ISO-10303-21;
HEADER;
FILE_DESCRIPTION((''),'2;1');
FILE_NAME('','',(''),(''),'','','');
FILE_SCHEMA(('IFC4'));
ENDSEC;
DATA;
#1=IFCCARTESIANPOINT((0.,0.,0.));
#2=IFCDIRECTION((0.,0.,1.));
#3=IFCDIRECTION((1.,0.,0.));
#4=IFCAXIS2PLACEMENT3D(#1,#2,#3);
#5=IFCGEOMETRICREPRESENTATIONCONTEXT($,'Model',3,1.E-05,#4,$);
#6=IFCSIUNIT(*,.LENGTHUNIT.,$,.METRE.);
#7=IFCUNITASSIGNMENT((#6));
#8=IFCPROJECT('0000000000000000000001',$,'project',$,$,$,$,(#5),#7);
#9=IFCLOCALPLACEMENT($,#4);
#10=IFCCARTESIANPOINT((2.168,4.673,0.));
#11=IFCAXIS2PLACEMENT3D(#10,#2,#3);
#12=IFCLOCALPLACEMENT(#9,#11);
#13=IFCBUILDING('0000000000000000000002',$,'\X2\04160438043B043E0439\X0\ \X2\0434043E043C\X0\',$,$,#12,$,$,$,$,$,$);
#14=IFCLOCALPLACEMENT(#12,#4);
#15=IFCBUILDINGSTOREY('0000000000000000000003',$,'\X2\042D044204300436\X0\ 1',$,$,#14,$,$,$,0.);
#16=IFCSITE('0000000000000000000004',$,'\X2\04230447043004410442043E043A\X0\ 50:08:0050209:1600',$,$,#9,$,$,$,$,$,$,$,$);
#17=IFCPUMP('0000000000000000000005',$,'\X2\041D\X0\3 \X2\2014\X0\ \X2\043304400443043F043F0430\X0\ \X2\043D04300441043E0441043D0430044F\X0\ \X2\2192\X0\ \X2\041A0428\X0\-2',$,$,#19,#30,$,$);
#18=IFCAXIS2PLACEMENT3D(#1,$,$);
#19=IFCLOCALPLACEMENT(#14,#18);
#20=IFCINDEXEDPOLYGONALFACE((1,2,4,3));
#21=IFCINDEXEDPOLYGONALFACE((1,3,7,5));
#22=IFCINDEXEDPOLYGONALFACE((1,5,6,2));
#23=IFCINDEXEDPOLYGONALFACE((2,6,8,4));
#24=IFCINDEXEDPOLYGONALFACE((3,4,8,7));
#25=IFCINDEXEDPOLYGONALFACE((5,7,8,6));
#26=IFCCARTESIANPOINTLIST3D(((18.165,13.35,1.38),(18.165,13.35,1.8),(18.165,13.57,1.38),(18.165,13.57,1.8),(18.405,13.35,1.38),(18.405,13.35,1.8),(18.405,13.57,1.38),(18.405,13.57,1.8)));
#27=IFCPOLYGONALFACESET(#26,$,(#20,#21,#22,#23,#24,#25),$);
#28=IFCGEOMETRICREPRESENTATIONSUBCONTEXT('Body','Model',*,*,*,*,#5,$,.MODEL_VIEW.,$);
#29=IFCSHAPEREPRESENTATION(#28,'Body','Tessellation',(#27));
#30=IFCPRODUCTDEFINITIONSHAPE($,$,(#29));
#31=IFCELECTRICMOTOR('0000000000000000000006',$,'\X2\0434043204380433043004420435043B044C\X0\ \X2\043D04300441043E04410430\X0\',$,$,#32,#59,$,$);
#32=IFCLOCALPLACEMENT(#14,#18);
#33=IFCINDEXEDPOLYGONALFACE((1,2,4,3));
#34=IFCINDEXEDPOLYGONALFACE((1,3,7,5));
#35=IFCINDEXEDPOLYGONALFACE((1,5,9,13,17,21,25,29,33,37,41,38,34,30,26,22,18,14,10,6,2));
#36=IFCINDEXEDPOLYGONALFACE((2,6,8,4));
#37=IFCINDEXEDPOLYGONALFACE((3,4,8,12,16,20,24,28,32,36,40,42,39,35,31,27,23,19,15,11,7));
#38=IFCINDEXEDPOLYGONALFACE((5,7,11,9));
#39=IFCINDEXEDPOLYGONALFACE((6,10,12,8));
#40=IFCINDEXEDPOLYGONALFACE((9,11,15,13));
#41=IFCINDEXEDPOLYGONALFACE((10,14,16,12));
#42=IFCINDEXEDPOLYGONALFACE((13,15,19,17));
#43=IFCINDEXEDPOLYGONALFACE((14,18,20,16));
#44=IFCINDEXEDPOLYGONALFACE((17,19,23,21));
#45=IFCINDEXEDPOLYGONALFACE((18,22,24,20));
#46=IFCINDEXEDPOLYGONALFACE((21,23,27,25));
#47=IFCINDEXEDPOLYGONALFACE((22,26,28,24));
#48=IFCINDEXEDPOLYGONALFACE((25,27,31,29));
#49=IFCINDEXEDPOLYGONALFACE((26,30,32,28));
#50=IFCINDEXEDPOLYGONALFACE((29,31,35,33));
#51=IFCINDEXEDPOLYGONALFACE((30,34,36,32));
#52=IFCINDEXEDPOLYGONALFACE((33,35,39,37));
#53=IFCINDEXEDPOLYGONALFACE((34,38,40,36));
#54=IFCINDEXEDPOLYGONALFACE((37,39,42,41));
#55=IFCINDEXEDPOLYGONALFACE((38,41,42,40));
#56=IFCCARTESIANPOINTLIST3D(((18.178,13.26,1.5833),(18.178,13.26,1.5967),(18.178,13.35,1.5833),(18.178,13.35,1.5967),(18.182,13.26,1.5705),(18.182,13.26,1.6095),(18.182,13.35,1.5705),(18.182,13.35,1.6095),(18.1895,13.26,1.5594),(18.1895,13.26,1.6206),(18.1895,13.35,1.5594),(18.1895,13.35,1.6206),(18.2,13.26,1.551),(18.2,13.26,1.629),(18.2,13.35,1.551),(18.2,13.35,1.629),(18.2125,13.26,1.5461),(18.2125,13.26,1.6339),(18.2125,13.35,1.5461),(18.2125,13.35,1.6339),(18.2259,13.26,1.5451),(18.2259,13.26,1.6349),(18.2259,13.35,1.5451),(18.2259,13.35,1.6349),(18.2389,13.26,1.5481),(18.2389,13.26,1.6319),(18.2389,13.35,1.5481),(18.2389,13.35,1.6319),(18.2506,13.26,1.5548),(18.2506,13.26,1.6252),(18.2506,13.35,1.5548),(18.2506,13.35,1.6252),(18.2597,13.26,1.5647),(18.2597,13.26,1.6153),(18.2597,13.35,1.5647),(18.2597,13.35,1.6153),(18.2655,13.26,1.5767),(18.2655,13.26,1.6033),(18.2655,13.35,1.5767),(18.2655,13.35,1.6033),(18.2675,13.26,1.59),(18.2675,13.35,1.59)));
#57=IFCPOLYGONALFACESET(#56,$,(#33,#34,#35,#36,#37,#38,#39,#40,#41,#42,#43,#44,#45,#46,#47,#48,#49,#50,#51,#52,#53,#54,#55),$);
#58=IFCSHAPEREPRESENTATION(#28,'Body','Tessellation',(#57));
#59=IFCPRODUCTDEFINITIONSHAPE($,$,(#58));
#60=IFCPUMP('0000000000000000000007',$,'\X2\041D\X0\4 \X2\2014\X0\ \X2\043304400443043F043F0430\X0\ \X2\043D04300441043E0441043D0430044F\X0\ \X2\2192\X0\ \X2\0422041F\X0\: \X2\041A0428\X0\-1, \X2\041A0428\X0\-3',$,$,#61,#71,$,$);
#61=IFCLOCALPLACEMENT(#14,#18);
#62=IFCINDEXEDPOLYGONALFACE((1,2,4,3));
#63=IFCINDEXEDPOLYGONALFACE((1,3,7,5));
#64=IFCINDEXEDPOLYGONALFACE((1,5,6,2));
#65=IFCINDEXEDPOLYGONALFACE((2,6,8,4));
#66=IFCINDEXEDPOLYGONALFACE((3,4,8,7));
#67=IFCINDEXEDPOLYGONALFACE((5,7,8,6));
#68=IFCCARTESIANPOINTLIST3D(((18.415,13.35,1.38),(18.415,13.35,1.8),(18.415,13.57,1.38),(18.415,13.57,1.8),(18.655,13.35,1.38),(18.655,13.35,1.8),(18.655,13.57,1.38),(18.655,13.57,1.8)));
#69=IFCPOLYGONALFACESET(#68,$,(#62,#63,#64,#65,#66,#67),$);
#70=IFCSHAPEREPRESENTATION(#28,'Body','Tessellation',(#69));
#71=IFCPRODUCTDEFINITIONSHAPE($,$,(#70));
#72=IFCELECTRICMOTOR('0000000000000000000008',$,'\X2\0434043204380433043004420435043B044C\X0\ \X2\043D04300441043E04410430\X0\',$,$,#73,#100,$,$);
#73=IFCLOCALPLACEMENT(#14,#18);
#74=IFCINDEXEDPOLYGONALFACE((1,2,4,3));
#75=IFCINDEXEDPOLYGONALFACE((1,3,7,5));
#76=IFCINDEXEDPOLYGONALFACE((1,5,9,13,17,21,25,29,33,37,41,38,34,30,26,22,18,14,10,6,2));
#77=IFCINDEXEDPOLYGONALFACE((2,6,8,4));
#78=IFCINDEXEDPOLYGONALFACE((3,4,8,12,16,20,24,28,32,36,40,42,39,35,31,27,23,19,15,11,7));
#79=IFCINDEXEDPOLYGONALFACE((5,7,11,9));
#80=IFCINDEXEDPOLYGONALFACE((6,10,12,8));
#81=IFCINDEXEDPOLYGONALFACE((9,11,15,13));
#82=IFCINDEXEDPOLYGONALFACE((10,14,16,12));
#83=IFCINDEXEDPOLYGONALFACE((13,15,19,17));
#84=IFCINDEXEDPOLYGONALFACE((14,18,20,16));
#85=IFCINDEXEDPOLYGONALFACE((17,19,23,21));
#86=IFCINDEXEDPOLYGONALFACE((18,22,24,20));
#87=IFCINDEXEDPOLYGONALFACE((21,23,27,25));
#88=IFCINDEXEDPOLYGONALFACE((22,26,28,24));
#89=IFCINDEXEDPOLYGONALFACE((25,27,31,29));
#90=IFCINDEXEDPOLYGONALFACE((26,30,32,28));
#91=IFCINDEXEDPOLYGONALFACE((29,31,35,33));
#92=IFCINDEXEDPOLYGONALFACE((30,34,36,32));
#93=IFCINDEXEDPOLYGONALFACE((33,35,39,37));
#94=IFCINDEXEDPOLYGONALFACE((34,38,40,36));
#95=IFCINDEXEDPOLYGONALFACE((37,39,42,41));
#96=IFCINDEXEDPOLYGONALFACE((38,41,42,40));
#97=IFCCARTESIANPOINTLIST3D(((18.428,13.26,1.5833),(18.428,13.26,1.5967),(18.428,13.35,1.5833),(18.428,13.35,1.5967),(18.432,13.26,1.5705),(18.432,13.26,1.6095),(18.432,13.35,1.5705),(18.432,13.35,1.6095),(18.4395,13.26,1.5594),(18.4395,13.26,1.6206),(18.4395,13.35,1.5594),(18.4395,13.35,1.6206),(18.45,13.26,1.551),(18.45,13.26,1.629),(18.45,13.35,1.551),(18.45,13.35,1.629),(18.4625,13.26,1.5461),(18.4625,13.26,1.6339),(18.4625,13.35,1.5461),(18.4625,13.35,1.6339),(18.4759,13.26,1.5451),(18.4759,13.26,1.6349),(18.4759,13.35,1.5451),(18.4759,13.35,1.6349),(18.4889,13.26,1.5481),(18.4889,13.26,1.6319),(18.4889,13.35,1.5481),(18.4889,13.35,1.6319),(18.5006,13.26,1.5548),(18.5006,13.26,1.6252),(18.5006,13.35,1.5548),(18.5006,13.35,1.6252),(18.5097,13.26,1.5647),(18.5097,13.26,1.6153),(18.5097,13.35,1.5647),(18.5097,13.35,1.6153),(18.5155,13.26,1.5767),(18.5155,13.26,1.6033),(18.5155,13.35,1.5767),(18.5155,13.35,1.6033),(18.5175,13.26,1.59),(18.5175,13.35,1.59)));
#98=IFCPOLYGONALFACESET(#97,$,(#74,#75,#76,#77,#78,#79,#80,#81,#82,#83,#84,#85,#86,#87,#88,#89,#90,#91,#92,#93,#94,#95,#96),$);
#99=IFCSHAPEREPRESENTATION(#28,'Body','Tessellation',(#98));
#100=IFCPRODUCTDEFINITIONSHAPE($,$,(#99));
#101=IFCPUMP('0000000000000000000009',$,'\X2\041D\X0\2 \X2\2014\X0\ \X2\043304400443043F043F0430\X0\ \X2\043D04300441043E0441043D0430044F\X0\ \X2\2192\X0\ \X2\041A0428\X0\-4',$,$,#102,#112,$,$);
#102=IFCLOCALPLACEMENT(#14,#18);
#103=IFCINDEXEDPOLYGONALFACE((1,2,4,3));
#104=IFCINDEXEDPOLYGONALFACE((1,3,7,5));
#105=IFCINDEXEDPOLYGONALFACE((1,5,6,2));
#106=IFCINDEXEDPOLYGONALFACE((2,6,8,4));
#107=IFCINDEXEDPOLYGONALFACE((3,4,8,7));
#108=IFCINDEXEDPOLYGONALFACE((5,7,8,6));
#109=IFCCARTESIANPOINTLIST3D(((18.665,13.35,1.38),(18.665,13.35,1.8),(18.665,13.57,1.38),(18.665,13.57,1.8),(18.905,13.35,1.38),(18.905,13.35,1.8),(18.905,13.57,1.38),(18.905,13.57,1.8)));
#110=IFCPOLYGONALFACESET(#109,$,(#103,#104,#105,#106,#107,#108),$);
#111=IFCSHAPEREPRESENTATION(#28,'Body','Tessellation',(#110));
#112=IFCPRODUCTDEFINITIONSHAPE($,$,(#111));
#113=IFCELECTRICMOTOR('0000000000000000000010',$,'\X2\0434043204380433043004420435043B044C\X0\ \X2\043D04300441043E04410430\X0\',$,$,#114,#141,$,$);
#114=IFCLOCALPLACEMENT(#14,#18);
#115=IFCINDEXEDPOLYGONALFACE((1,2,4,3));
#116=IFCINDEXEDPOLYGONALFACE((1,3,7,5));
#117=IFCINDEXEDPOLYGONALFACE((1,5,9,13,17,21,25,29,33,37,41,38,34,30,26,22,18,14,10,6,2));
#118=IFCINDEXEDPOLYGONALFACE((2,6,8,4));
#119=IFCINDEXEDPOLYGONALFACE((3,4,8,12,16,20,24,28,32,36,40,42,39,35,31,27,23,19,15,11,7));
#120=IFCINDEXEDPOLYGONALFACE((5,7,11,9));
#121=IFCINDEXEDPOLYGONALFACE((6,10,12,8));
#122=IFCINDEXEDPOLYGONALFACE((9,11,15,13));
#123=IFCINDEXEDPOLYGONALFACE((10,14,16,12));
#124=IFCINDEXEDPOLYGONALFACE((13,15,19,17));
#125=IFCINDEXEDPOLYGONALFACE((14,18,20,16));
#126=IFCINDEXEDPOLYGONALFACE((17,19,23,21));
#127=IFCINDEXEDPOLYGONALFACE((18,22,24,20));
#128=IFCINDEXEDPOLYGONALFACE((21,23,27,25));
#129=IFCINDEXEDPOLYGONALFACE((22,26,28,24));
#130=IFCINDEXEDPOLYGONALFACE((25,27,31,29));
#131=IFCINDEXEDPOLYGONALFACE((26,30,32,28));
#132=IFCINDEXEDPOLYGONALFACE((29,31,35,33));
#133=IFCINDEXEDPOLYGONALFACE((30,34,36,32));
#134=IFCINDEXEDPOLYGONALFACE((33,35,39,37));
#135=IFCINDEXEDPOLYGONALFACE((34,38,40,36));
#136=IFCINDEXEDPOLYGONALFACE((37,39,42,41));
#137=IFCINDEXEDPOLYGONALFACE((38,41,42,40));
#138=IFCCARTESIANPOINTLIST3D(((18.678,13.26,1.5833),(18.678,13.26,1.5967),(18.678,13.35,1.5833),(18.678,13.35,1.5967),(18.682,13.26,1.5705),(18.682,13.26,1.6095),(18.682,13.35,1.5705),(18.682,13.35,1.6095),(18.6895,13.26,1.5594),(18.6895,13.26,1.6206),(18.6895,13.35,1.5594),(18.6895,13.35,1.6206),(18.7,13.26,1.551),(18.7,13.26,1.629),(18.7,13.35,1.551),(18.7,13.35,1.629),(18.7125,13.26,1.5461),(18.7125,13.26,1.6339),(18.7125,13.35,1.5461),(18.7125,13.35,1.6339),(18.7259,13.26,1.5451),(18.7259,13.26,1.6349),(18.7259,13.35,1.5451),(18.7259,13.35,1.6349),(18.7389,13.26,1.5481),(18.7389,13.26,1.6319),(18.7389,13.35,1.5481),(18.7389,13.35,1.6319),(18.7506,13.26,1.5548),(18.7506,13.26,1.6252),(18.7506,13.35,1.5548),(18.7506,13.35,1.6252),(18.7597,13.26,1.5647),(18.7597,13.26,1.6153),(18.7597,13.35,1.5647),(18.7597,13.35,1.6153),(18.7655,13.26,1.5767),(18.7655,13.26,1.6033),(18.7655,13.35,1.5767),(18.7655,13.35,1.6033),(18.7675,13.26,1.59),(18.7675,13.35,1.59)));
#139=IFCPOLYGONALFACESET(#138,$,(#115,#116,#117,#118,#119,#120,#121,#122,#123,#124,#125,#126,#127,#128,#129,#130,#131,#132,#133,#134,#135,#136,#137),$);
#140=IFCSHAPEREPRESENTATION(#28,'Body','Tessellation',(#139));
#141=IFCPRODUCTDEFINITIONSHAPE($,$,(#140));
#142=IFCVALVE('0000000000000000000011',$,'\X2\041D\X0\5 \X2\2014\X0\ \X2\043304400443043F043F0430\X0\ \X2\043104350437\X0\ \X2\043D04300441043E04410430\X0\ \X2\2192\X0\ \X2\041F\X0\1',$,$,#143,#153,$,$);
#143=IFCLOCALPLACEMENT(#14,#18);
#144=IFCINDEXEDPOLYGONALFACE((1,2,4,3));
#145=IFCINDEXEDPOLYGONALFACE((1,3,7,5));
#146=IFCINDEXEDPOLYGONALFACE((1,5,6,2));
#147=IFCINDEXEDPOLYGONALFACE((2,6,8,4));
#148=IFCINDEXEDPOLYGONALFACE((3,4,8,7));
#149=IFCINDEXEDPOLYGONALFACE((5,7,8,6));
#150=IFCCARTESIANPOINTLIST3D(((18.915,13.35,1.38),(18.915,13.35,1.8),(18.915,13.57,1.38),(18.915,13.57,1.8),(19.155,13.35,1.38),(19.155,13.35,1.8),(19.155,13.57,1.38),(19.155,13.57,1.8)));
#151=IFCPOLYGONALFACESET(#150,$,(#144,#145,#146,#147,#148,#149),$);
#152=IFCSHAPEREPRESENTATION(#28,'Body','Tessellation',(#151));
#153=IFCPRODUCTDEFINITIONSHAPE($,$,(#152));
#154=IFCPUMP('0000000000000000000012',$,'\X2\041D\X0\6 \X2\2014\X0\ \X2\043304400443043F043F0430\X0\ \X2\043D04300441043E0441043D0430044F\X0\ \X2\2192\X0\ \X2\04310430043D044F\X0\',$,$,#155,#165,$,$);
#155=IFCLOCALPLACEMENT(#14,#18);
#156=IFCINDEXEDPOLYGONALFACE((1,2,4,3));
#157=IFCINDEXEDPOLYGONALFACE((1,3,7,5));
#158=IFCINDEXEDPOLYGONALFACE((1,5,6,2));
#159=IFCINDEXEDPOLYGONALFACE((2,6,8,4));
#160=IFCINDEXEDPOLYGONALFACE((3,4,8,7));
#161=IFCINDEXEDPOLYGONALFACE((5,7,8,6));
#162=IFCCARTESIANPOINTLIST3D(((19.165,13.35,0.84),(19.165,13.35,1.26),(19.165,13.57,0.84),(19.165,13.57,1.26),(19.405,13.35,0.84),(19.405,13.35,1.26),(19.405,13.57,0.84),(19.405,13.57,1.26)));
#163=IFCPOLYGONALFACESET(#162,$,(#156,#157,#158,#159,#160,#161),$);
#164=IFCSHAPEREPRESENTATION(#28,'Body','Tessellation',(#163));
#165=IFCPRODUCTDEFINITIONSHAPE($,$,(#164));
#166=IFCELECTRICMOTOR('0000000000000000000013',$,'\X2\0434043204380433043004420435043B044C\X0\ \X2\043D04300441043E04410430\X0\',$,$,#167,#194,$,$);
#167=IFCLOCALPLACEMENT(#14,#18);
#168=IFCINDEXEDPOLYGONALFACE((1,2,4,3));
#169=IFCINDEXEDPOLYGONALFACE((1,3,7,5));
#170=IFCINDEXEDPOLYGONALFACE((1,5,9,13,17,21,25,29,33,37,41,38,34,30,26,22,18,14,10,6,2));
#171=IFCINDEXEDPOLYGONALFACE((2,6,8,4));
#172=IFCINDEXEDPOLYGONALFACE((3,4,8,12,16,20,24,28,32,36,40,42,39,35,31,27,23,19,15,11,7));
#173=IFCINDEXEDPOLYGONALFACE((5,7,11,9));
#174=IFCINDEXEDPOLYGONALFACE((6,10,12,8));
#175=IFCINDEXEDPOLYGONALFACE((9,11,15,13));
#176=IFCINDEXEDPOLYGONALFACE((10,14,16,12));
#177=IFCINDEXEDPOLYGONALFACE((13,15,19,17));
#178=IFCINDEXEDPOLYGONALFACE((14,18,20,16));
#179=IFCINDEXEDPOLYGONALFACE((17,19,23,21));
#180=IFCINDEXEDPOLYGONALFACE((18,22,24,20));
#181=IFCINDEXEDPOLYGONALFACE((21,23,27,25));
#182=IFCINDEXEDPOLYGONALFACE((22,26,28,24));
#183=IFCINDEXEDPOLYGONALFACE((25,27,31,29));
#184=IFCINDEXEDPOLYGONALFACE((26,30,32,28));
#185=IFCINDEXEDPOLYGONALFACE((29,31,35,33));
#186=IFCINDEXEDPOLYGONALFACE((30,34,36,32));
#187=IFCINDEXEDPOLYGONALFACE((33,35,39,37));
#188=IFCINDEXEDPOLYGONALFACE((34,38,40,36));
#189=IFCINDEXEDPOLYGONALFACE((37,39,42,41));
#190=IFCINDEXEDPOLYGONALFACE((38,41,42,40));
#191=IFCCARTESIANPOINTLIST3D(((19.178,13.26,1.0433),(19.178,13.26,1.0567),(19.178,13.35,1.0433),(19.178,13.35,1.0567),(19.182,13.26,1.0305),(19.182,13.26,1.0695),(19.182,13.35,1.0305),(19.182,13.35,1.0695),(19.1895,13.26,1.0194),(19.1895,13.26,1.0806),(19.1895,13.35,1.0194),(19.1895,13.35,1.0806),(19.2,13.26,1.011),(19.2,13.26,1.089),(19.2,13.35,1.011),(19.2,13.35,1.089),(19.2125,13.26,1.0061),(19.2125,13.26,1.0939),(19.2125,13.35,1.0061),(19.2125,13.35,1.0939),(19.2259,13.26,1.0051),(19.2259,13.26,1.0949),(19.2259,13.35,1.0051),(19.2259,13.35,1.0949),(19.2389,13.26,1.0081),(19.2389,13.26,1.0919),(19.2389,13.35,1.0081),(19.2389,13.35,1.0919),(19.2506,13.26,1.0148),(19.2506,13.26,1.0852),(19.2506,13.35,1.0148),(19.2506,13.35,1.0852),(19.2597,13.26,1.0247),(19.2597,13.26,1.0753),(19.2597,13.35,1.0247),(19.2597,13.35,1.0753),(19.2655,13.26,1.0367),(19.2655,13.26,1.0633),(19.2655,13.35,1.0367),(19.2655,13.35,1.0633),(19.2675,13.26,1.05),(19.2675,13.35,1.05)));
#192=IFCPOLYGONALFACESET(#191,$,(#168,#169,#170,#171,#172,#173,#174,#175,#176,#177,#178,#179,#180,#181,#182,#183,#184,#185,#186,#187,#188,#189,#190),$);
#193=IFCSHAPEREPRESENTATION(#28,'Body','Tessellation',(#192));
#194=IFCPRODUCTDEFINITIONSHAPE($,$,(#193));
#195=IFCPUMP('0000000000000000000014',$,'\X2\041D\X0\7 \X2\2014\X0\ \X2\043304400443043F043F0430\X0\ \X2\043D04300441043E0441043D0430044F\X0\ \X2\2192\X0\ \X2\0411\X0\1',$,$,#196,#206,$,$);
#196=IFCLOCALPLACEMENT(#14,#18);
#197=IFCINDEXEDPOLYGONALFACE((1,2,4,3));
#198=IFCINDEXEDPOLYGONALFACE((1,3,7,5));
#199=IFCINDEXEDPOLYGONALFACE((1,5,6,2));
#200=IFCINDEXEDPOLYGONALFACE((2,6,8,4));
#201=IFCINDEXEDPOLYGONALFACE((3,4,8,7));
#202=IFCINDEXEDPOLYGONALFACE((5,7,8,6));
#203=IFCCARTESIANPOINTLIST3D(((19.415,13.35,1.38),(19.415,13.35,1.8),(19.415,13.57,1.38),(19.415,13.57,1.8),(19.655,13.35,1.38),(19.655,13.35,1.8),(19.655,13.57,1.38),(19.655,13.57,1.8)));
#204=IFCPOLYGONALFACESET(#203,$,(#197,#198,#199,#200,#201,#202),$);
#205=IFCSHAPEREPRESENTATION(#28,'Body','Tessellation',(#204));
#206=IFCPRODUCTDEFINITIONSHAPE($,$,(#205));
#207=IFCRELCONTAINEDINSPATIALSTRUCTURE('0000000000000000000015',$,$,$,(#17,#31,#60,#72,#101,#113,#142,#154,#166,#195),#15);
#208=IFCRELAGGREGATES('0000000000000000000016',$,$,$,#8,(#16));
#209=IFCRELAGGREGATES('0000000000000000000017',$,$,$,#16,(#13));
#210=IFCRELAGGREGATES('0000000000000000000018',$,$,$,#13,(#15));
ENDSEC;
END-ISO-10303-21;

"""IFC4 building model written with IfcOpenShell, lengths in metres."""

from ifc_helpers import new_model, si_unit, frame, frame_2d, origin_with_axes, origin_2d, place, context, subcontext, project, spatial, rectangle, circle, extrude, element, save


model = new_model("IFC4")

# Units and contexts
model_context = context("Model", 3, precision=1e-05, world=origin_with_axes())
body_context = subcontext(model_context, "Body", "Model", "MODEL_VIEW")
ifc_project = project(units=[si_unit("LENGTHUNIT", "METRE")], contexts=[model_context])

# Site, building, storey
site_placement = place(None, origin_with_axes())
site = spatial("IfcSite", under=ifc_project, at=site_placement, Name="Участок 50:08:0050209:1600")
building_placement = place(site_placement, frame((2.168, 4.673, 0.0), z_axis=(0.0, 0.0, 1.0), x_axis=(1.0, 0.0, 0.0)))
building = spatial("IfcBuilding", under=site, at=building_placement, Name="Жилой дом")
storey_placement = place(building_placement, origin_with_axes())
storey = spatial("IfcBuildingStorey", under=building, at=storey_placement, Name="Этаж 1", Elevation=0.0)

# Pump
pump_1_placement = place(storey_placement, origin_with_axes())
element("IfcPump", 1, at=pump_1_placement, inside=storey, Name="Н3 — группа насосная → КШ-2", context=body_context, shape_type="SweptSolid", body=[
    extrude(rectangle(XDim=0.24, YDim=0.22, at=frame_2d((0.12, 0.11))), frame((18.165, 13.35, 1.38), z_axis=(0.0, 0.0, 1.0), x_axis=(1.0, 0.0, 0.0)), (0.0, 0.0, 1.0), 0.42),
])

# Electric motor
electric_motor_1_placement = place(storey_placement, origin_with_axes())
element("IfcElectricMotor", 2, at=electric_motor_1_placement, inside=storey, Name="двигатель насоса", context=body_context, shape_type="SweptSolid", body=[
    extrude(circle(Radius=0.045, at=origin_2d()), frame((18.2225, 13.35, 1.59), z_axis=(0.0, -1.0, 0.0), x_axis=(1.0, 0.0, 0.0)), (0.0, 0.0, 1.0), 0.09),
])

# Pump
pump_2_placement = place(storey_placement, origin_with_axes())
element("IfcPump", 3, at=pump_2_placement, inside=storey, Name="Н4 — группа насосная → ТП: КШ-1, КШ-3", context=body_context, shape_type="SweptSolid", body=[
    extrude(rectangle(XDim=0.24, YDim=0.22, at=frame_2d((0.12, 0.11))), frame((18.415, 13.35, 1.38), z_axis=(0.0, 0.0, 1.0), x_axis=(1.0, 0.0, 0.0)), (0.0, 0.0, 1.0), 0.42),
])

# Electric motor
electric_motor_2_placement = place(storey_placement, origin_with_axes())
element("IfcElectricMotor", 4, at=electric_motor_2_placement, inside=storey, Name="двигатель насоса", context=body_context, shape_type="SweptSolid", body=[
    extrude(circle(Radius=0.045, at=origin_2d()), frame((18.4725, 13.35, 1.59), z_axis=(0.0, -1.0, 0.0), x_axis=(1.0, 0.0, 0.0)), (0.0, 0.0, 1.0), 0.09),
])

# Pump
pump_3_placement = place(storey_placement, origin_with_axes())
element("IfcPump", 5, at=pump_3_placement, inside=storey, Name="Н2 — группа насосная → КШ-4", context=body_context, shape_type="SweptSolid", body=[
    extrude(rectangle(XDim=0.24, YDim=0.22, at=frame_2d((0.12, 0.11))), frame((18.665, 13.35, 1.38), z_axis=(0.0, 0.0, 1.0), x_axis=(1.0, 0.0, 0.0)), (0.0, 0.0, 1.0), 0.42),
])

# Electric motor
electric_motor_3_placement = place(storey_placement, origin_with_axes())
element("IfcElectricMotor", 6, at=electric_motor_3_placement, inside=storey, Name="двигатель насоса", context=body_context, shape_type="SweptSolid", body=[
    extrude(circle(Radius=0.045, at=origin_2d()), frame((18.7225, 13.35, 1.59), z_axis=(0.0, -1.0, 0.0), x_axis=(1.0, 0.0, 0.0)), (0.0, 0.0, 1.0), 0.09),
])

# Valve
valve_1_placement = place(storey_placement, origin_with_axes())
element("IfcValve", 7, at=valve_1_placement, inside=storey, Name="Н5 — группа без насоса → П1", context=body_context, shape_type="SweptSolid", body=[
    extrude(rectangle(XDim=0.24, YDim=0.22, at=frame_2d((0.12, 0.11))), frame((18.915, 13.35, 1.38), z_axis=(0.0, 0.0, 1.0), x_axis=(1.0, 0.0, 0.0)), (0.0, 0.0, 1.0), 0.42),
])

# Pump
pump_4_placement = place(storey_placement, origin_with_axes())
element("IfcPump", 8, at=pump_4_placement, inside=storey, Name="Н6 — группа насосная → баня", context=body_context, shape_type="SweptSolid", body=[
    extrude(rectangle(XDim=0.24, YDim=0.22, at=frame_2d((0.12, 0.11))), frame((19.165, 13.35, 0.84), z_axis=(0.0, 0.0, 1.0), x_axis=(1.0, 0.0, 0.0)), (0.0, 0.0, 1.0), 0.42),
])

# Electric motor
electric_motor_4_placement = place(storey_placement, origin_with_axes())
element("IfcElectricMotor", 9, at=electric_motor_4_placement, inside=storey, Name="двигатель насоса", context=body_context, shape_type="SweptSolid", body=[
    extrude(circle(Radius=0.045, at=origin_2d()), frame((19.2225, 13.35, 1.05), z_axis=(0.0, -1.0, 0.0), x_axis=(1.0, 0.0, 0.0)), (0.0, 0.0, 1.0), 0.09),
])

# Pump
pump_5_placement = place(storey_placement, origin_with_axes())
element("IfcPump", 10, at=pump_5_placement, inside=storey, Name="Н7 — группа насосная → Б1", context=body_context, shape_type="SweptSolid", body=[
    extrude(rectangle(XDim=0.24, YDim=0.22, at=frame_2d((0.12, 0.11))), frame((19.415, 13.35, 1.38), z_axis=(0.0, 0.0, 1.0), x_axis=(1.0, 0.0, 0.0)), (0.0, 0.0, 1.0), 0.42),
])

save(model, "model.ifc")
